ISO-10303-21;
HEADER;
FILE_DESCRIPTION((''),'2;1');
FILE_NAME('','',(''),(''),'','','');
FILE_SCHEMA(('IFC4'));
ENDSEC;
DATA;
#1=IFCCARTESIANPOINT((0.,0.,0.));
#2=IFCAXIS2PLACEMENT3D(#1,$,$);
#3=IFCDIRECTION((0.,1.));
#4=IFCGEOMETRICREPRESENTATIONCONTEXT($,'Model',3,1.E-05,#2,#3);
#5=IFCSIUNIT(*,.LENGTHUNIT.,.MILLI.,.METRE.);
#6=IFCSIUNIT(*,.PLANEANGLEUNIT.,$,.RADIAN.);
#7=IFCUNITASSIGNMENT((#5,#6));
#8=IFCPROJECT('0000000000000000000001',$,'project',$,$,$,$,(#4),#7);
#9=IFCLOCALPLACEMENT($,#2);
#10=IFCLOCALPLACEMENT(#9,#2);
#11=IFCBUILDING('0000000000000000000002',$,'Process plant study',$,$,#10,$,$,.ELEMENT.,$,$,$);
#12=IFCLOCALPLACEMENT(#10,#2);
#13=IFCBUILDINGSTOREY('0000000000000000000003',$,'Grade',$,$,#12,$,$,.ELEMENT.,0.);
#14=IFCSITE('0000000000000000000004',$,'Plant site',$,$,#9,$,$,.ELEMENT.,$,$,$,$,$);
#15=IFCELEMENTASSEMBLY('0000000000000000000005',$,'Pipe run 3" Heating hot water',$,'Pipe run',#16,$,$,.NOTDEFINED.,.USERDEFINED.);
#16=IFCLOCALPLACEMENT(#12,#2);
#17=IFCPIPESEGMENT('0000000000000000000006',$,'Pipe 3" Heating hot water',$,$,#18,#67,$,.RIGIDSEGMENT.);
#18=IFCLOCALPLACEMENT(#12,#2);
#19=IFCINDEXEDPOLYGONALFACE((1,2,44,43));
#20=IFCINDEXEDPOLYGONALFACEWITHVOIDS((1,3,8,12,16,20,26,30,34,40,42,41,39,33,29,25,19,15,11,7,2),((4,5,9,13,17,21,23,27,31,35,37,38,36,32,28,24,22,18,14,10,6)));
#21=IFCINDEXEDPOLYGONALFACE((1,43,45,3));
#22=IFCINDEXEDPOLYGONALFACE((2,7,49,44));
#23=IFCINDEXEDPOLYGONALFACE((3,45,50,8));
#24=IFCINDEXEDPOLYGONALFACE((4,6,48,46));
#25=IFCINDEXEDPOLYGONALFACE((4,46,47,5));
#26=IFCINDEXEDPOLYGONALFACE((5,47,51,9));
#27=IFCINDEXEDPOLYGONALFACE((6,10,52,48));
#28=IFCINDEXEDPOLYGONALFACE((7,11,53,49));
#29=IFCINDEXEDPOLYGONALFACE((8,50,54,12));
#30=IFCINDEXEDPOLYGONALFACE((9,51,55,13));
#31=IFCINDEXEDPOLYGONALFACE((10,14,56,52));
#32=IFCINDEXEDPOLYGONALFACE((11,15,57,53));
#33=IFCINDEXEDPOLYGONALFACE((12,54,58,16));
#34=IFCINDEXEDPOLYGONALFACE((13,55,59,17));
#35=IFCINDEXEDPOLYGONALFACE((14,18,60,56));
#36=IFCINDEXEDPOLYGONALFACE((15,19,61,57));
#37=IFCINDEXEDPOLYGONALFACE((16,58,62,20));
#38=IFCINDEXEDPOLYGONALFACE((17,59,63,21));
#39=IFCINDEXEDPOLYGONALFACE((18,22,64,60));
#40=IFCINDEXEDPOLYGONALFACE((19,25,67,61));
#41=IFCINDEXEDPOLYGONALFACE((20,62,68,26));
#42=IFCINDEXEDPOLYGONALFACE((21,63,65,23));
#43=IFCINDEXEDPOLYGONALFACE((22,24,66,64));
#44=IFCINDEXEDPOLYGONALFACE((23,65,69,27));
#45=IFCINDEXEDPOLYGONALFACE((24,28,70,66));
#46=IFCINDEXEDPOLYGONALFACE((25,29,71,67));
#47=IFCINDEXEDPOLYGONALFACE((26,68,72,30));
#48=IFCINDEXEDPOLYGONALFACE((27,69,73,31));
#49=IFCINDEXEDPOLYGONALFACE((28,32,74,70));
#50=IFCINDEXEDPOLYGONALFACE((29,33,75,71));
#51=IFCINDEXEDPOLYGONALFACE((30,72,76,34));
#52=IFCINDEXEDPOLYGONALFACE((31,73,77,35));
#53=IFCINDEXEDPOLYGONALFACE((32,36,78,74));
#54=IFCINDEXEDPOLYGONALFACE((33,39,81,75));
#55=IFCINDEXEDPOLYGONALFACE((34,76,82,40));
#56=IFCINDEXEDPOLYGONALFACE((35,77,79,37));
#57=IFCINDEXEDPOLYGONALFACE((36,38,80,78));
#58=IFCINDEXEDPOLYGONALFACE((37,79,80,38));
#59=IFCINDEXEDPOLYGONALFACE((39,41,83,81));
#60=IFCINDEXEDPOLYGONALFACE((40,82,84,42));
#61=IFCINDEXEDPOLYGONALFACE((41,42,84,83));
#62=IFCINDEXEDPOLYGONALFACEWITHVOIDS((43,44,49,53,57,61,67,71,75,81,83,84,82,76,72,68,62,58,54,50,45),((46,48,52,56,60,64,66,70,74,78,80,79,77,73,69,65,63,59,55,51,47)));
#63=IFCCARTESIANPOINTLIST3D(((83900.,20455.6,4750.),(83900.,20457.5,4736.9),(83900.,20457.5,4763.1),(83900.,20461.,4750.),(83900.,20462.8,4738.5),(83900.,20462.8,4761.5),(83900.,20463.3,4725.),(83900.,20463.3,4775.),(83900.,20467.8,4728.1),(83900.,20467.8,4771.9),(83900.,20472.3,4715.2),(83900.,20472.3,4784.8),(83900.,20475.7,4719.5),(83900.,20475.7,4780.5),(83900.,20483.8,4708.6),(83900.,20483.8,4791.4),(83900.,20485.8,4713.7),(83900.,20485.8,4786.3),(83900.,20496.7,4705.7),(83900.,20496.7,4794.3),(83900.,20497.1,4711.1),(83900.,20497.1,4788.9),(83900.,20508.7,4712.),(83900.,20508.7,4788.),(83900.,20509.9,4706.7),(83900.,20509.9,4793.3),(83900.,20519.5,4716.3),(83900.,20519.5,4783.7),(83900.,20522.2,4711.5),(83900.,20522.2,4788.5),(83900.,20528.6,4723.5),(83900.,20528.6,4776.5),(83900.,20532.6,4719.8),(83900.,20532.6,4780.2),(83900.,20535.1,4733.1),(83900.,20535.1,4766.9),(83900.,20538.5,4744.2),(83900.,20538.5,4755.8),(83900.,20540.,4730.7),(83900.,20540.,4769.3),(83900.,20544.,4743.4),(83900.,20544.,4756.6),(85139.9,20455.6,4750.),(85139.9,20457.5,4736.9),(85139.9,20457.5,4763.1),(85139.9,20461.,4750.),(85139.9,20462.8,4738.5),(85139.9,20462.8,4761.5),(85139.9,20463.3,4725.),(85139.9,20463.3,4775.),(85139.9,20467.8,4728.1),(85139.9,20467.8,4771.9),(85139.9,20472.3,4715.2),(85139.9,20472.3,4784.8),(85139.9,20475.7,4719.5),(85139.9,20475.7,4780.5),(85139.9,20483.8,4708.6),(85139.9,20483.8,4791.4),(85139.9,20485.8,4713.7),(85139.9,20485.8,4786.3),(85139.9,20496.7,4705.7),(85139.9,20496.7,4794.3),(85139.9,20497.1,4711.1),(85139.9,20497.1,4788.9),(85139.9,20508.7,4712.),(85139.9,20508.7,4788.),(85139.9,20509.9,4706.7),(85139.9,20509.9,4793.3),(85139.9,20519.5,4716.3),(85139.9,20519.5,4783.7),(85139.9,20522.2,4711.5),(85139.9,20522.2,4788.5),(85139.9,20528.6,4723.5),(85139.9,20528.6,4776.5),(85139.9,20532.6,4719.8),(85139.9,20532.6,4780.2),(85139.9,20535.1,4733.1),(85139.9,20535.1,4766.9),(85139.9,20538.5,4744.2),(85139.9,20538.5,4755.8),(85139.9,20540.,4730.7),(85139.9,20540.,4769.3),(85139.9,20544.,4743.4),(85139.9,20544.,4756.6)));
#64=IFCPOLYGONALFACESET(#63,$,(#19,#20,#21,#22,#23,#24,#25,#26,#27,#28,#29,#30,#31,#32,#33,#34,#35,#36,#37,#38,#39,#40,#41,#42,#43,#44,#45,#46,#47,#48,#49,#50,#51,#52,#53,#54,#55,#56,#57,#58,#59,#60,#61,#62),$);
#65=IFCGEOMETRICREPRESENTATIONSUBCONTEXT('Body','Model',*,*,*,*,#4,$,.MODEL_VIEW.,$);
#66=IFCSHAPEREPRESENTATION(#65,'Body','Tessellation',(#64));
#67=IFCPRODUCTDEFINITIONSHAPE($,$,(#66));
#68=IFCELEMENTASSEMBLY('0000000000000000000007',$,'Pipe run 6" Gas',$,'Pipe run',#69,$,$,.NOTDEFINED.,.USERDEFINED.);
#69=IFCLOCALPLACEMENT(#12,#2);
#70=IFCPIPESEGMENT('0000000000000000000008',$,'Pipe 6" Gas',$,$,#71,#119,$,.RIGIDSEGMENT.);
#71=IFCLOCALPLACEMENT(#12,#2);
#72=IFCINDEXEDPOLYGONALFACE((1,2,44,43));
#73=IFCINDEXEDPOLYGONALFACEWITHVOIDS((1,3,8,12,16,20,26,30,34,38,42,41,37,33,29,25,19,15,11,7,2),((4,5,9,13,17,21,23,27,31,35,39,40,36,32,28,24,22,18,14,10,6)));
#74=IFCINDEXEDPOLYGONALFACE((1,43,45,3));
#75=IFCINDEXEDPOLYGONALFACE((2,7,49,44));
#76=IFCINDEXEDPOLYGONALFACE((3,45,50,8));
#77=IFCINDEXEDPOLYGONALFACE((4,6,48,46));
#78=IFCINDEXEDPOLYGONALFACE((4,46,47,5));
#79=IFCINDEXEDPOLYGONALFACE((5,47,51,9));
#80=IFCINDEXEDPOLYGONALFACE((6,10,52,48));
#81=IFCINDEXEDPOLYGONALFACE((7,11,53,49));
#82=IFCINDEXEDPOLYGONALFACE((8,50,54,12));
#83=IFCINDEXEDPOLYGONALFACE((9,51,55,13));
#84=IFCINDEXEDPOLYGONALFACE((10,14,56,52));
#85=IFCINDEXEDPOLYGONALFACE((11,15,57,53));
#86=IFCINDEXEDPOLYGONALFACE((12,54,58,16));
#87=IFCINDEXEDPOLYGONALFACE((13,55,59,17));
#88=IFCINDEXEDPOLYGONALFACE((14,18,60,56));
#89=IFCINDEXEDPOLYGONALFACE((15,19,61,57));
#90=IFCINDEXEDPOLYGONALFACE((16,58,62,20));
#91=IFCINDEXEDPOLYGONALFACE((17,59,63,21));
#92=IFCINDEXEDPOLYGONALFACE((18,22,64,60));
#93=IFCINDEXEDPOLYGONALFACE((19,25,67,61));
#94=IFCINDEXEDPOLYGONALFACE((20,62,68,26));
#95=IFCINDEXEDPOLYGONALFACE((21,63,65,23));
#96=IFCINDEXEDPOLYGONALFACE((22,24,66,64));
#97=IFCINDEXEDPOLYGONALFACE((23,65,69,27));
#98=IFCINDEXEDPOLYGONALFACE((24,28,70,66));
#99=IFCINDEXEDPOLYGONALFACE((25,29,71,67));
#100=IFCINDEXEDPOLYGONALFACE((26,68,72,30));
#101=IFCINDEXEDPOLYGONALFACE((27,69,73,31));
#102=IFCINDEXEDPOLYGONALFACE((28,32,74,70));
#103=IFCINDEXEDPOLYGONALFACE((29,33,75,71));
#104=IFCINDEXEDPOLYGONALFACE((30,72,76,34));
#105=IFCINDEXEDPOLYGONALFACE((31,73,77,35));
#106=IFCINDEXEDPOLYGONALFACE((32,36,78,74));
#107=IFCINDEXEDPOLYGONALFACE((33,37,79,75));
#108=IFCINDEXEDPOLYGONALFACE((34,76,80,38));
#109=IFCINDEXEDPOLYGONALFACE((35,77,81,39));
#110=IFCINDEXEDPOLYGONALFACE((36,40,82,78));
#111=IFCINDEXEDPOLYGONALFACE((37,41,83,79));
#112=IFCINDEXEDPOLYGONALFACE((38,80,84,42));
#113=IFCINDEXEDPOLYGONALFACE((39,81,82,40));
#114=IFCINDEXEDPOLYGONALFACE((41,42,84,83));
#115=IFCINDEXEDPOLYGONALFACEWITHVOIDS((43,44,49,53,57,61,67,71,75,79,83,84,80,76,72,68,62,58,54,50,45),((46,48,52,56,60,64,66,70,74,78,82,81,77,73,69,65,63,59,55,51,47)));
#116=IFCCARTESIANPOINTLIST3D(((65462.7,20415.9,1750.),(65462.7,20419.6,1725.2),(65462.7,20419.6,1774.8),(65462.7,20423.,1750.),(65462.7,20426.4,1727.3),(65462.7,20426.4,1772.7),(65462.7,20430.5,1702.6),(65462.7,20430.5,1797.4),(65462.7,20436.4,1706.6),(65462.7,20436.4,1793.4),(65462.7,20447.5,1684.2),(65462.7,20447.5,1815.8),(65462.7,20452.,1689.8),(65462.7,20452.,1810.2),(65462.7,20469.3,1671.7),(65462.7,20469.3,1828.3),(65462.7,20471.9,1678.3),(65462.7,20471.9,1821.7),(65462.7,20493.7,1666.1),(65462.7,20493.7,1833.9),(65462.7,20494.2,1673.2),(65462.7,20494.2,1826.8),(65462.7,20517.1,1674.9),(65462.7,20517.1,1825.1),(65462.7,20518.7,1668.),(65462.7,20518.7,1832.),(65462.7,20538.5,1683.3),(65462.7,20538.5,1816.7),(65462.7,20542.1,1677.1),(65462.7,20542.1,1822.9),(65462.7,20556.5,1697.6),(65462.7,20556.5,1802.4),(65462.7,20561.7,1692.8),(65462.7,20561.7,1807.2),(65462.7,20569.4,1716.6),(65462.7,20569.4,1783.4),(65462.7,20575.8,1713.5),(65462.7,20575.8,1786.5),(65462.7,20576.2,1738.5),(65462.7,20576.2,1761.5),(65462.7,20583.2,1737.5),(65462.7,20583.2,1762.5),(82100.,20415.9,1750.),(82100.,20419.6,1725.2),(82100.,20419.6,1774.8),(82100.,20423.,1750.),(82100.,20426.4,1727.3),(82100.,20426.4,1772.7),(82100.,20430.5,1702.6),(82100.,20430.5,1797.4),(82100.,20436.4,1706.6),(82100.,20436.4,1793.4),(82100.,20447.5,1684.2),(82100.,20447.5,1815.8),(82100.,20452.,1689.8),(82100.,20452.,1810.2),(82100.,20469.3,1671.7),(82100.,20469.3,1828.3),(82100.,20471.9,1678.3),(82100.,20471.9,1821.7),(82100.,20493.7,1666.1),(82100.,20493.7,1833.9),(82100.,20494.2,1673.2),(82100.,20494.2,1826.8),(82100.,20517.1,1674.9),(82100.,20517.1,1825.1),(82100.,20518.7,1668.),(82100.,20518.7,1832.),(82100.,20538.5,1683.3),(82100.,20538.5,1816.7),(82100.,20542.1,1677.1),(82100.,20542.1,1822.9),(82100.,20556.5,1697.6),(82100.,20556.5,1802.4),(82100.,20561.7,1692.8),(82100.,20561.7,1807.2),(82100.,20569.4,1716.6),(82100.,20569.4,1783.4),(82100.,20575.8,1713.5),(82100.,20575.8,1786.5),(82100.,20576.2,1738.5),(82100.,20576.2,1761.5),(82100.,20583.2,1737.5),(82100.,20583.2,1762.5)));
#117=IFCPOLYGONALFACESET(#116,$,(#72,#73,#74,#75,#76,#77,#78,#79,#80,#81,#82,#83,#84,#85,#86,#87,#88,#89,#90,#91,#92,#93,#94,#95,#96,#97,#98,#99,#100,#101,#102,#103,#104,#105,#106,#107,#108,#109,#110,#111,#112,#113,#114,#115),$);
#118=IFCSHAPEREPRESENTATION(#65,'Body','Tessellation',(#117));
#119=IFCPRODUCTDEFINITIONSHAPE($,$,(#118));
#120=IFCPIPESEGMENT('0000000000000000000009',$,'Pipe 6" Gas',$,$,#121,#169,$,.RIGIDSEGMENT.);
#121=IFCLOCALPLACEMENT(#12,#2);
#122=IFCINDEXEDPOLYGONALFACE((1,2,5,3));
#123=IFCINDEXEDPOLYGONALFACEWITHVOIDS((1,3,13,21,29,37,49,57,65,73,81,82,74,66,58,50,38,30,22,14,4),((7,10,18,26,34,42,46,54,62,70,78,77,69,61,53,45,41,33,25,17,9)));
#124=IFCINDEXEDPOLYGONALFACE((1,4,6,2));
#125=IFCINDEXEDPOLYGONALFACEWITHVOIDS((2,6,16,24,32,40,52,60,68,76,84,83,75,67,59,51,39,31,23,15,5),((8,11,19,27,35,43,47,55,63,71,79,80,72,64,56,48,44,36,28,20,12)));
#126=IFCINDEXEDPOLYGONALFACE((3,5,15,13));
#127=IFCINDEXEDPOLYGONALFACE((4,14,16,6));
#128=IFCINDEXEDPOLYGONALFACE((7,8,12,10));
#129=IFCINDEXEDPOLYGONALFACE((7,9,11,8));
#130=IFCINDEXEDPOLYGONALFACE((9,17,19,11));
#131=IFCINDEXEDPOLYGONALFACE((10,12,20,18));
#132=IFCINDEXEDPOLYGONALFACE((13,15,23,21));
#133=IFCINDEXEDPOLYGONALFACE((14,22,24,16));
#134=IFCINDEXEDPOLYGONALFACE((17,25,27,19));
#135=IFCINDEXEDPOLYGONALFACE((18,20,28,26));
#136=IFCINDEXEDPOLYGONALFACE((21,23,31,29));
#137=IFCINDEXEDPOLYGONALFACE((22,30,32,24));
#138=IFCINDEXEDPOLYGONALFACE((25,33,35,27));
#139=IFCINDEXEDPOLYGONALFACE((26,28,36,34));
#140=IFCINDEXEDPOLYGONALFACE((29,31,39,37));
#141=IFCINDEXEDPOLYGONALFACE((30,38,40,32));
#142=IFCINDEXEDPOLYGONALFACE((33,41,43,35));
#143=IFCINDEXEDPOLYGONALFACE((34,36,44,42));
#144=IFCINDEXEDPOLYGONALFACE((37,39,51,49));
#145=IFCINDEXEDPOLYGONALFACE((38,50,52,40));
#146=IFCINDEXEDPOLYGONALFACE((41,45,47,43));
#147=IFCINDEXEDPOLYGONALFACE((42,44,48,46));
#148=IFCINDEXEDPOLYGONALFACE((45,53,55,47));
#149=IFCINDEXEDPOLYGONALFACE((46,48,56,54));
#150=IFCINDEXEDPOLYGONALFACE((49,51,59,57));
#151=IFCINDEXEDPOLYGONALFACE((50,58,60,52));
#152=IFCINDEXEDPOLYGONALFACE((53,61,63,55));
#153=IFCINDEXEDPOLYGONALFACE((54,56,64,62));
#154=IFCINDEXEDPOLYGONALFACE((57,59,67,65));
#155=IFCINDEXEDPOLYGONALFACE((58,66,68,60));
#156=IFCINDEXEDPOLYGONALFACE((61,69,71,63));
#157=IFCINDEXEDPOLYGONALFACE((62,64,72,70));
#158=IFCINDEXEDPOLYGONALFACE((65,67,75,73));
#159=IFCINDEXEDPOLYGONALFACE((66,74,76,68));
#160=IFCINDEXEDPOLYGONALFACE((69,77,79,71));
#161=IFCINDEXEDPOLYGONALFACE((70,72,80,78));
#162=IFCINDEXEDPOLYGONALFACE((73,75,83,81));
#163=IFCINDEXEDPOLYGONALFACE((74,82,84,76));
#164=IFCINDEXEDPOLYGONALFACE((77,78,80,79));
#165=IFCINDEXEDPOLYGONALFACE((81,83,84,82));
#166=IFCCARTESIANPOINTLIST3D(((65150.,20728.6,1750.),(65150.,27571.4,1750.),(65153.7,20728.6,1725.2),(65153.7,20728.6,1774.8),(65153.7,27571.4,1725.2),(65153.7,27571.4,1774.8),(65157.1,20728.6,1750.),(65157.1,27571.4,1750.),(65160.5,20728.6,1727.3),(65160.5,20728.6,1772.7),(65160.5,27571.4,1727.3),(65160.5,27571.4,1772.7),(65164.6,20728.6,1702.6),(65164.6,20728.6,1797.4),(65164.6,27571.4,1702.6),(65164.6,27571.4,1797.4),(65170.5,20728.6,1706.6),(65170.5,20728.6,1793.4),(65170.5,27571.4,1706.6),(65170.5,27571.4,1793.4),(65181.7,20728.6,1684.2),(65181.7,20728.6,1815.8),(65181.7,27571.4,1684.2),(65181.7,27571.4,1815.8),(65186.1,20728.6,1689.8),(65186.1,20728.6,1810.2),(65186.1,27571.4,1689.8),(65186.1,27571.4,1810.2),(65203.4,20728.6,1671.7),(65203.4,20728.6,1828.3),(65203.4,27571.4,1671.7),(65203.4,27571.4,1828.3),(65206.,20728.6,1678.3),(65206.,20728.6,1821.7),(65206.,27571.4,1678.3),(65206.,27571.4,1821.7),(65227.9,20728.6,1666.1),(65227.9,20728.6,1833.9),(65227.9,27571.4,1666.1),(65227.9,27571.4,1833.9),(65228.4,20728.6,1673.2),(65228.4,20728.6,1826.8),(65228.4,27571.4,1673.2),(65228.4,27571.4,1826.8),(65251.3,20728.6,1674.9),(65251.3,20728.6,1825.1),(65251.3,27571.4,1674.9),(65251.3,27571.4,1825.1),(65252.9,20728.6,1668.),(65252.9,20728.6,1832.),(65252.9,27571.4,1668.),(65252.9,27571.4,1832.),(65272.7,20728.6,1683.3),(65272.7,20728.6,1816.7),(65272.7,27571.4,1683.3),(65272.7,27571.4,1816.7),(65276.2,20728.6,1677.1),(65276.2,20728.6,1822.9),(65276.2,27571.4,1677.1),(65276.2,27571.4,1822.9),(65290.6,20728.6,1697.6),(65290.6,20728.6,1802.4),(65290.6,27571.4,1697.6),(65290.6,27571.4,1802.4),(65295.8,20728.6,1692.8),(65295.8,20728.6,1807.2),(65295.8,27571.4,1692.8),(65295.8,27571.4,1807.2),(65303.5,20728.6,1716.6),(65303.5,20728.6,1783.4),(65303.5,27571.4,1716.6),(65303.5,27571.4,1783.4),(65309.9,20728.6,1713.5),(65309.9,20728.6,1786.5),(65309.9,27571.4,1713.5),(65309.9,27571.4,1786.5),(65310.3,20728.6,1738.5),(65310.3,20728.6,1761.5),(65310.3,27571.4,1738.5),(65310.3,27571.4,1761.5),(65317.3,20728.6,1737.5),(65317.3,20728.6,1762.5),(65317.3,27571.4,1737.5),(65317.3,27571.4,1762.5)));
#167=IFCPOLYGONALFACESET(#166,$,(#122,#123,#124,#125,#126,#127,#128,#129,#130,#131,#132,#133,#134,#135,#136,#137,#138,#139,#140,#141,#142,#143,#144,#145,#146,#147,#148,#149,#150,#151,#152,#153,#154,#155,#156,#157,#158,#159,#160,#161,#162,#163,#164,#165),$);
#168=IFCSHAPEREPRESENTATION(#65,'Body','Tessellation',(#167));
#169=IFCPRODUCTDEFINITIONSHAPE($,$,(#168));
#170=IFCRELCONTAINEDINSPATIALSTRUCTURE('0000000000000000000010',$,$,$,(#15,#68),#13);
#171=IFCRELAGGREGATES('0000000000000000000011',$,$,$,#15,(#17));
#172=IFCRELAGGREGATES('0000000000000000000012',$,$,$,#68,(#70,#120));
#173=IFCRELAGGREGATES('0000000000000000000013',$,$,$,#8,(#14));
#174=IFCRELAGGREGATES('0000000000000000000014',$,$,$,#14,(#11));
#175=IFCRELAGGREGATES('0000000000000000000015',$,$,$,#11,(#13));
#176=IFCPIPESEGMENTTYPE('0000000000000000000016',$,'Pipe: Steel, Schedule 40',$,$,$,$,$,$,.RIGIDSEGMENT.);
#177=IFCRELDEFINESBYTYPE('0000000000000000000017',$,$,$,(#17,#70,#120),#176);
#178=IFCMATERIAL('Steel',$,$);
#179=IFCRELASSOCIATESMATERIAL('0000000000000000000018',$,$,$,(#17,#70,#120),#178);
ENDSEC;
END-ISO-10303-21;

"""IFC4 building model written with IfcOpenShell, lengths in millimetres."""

from ifc_helpers import new_model, si_unit, direction, frame, origin, origin_with_axes, origin_2d, place, context, subcontext, project, spatial, hollow_circle, extrude, material, type_object, element, aggregate, save


model = new_model("IFC4")

# Units and contexts
model_context = context("Model", 3, precision=1e-05, world=origin(), true_north=direction((0.0, 1.0)))
body_context = subcontext(model_context, "Body", "Model", "MODEL_VIEW")
ifc_project = project(units=[si_unit("LENGTHUNIT", "METRE", prefix="MILLI"), si_unit("PLANEANGLEUNIT", "RADIAN")], contexts=[model_context])

# Site, building, storey
site_placement = place(None, origin())
site = spatial("IfcSite", under=ifc_project, at=site_placement, Name="Plant site", CompositionType="ELEMENT")
building_placement = place(site_placement, origin())
building = spatial("IfcBuilding", under=site, at=building_placement, Name="Process plant study", CompositionType="ELEMENT")
storey_placement = place(building_placement, origin())
storey = spatial("IfcBuildingStorey", under=building, at=storey_placement, Name="Grade", CompositionType="ELEMENT", Elevation=0.0)

# Element assemblies, pipe segments
ifc_material = material(Name="Steel")
pipe_segment_type = type_object("IfcPipeSegmentType", Name="Pipe: Steel, Schedule 40", PredefinedType="RIGIDSEGMENT")
assembly_1_placement = place(storey_placement, origin_with_axes())
assembly_1 = element("IfcElementAssembly", 1, at=assembly_1_placement, inside=storey, Name="Pipe run 3\" Heating hot water", ObjectType="Pipe run", AssemblyPlace="NOTDEFINED", PredefinedType="USERDEFINED")
pipe_segment_1_placement = place(storey_placement, origin_with_axes())
pipe_segment_1 = element("IfcPipeSegment", 2, at=pipe_segment_1_placement, type_object=pipe_segment_type, material=ifc_material, Name="Pipe 3\" Heating hot water", PredefinedType="RIGIDSEGMENT", context=body_context, shape_type="SweptSolid", body=[
    extrude(hollow_circle(Radius=44.5, WallThickness=5.5, at=origin_2d()), frame((85139.9, 20500.0, 4750.0), z_axis=(-1.0, 0.0, 0.0), x_axis=(0.0, -1.0, 0.0)), (0.0, 0.0, 1.0), 1239.9),
])
assembly_2_placement = place(storey_placement, origin_with_axes())
assembly_2 = element("IfcElementAssembly", 3, at=assembly_2_placement, inside=storey, Name="Pipe run 6\" Gas", ObjectType="Pipe run", AssemblyPlace="NOTDEFINED", PredefinedType="USERDEFINED")
pipe_segment_2_placement = place(storey_placement, origin_with_axes())
pipe_segment_2 = element("IfcPipeSegment", 4, at=pipe_segment_2_placement, type_object=pipe_segment_type, material=ifc_material, Name="Pipe 6\" Gas", PredefinedType="RIGIDSEGMENT", context=body_context, shape_type="SweptSolid", body=[
    extrude(hollow_circle(Radius=84.1, WallThickness=7.1, at=origin_2d()), frame((82100.0, 20500.0, 1750.0), z_axis=(-1.0, 0.0, 0.0), x_axis=(0.0, -1.0, 0.0)), (0.0, 0.0, 1.0), 16637.3),
])
pipe_segment_3_placement = place(storey_placement, origin_with_axes())
pipe_segment_3 = element("IfcPipeSegment", 5, at=pipe_segment_3_placement, type_object=pipe_segment_type, material=ifc_material, Name="Pipe 6\" Gas", PredefinedType="RIGIDSEGMENT", context=body_context, shape_type="SweptSolid", body=[
    extrude(hollow_circle(Radius=84.1, WallThickness=7.1, at=origin_2d()), frame((65234.1, 20728.6, 1750.0), z_axis=(0.0, 1.0, 0.0), x_axis=(-1.0, 0.0, 0.0)), (0.0, 0.0, 1.0), 6842.8),
])

aggregate(assembly_1, [pipe_segment_1])
aggregate(assembly_2, [pipe_segment_2, pipe_segment_3])

save(model, "model.ifc")
